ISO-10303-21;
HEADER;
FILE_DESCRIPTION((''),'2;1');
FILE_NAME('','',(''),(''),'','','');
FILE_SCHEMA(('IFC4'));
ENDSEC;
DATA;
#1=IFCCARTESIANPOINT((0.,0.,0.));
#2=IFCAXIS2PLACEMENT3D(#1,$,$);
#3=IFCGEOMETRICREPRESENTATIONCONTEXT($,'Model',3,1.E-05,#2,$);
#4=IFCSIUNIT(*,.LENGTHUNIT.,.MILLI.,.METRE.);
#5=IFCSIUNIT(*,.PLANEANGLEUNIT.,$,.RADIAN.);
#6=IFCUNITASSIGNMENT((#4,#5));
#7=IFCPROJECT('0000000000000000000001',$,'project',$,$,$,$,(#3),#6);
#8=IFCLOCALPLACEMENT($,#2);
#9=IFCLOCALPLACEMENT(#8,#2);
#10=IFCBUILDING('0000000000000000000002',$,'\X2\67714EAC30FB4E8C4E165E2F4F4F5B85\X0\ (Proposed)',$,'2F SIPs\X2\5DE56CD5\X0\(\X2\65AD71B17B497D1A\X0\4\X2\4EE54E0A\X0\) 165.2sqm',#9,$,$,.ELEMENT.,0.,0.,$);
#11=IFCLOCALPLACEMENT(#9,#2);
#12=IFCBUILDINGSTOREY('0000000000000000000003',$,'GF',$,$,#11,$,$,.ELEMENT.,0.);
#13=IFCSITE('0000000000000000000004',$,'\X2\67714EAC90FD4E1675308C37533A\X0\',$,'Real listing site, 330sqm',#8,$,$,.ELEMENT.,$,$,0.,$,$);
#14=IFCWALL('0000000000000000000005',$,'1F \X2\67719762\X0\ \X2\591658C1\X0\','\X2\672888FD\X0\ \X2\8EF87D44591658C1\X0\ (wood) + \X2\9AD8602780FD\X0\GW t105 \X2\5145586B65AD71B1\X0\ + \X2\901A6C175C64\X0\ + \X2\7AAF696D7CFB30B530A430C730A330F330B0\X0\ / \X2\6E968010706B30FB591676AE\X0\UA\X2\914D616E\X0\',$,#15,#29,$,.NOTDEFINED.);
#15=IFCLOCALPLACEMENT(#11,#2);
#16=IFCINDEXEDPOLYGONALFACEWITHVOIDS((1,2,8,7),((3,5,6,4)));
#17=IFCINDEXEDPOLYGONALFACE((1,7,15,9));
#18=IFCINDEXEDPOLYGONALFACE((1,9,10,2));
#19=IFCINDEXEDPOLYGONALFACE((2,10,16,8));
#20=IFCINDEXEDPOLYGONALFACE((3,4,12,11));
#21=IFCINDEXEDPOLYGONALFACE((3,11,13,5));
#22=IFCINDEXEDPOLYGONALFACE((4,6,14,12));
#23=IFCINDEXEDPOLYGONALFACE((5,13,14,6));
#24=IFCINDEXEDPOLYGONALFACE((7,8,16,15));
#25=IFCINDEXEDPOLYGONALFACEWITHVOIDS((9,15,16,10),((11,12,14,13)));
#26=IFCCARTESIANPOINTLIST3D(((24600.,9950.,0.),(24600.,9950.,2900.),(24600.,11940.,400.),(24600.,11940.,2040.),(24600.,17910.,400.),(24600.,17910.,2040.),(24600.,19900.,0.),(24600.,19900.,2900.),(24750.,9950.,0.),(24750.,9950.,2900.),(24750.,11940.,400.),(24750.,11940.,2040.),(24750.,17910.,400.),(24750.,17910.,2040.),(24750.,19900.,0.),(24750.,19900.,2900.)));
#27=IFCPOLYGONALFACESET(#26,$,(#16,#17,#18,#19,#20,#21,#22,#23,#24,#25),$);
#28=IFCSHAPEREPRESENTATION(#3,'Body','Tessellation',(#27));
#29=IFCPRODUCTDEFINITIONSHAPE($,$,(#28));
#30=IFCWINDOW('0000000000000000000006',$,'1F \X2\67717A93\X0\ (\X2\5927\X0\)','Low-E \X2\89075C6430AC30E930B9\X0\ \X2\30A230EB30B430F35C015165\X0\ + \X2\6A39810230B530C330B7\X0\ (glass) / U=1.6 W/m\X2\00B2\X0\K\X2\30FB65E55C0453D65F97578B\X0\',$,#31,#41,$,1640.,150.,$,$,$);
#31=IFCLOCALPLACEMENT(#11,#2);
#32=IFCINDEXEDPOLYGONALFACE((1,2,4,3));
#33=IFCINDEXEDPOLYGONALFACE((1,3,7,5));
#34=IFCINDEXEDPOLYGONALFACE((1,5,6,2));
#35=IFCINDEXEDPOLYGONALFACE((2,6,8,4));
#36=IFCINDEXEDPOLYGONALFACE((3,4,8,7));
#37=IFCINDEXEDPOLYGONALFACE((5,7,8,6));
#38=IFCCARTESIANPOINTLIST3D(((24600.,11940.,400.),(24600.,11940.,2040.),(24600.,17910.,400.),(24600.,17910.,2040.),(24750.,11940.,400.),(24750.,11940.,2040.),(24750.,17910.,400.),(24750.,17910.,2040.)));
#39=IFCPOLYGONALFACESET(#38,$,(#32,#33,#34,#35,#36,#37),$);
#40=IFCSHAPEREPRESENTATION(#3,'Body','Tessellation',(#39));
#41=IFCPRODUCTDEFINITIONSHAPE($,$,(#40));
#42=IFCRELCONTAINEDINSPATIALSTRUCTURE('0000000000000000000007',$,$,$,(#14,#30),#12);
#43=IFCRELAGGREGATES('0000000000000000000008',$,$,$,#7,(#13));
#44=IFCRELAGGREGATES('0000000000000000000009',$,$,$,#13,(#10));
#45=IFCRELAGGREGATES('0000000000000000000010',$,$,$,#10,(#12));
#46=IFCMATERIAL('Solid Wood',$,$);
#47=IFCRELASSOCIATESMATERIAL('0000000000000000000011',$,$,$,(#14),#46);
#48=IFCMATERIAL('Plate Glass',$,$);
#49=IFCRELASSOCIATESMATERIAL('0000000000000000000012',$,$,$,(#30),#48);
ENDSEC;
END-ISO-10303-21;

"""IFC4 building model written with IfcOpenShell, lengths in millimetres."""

from ifc_helpers import new_model, si_unit, frame, frame_2d, origin, place, context, project, spatial, rectangle, extrude, material, element, fill, save


model = new_model("IFC4")

# Units and contexts
model_context = context("Model", 3, precision=1e-05, world=origin())
ifc_project = project(units=[si_unit("LENGTHUNIT", "METRE", prefix="MILLI"), si_unit("PLANEANGLEUNIT", "RADIAN")], contexts=[model_context])

# Site, building, storey
site_placement = place(None, origin())
site = spatial("IfcSite", under=ifc_project, at=site_placement, Name="東京都世田谷区", ObjectType="Real listing site, 330sqm", CompositionType="ELEMENT", RefElevation=0.0)
building_placement = place(site_placement, origin())
building = spatial("IfcBuilding", under=site, at=building_placement, Name="東京・二世帯住宅 (Proposed)", ObjectType="2F SIPs工法(断熱等級4以上) 165.2sqm", CompositionType="ELEMENT", ElevationOfRefHeight=0.0, ElevationOfTerrain=0.0)
storey_placement = place(building_placement, origin())
storey = spatial("IfcBuildingStorey", under=building, at=storey_placement, Name="GF", CompositionType="ELEMENT", Elevation=0.0)

# Shared definitions
ifc_material_1 = material(Name="Solid Wood")

# Wall, opening, window
wall_1_placement = place(storey_placement, frame((12300.0, 4975.0, 0.0)))
wall_1 = element("IfcWall", 1, at=wall_1_placement, inside=storey, material=ifc_material_1, Name="1F 東面 外壁", Description="木製 軸組外壁 (wood) + 高性能GW t105 充填断熱 + 通気層 + 窯業系サイディング / 準耐火・外皮UA配慮", PredefinedType="NOTDEFINED", context=model_context, shape_type="SweptSolid", body=[
    extrude(rectangle(XDim=150.0, YDim=9950.0, at=frame_2d((75.0, 4975.0))), frame((12300.0, 4975.0, 0.0)), (0.0, 0.0, 1.0), 2900.0),
])
opening_1_placement = place(storey_placement, frame((12300.0, 5970.0, 200.0)))
opening_1 = element("IfcOpeningElement", 2, at=opening_1_placement, cuts=wall_1, PredefinedType="NOTDEFINED", context=model_context, shape_type="SweptSolid", body=[
    extrude(rectangle(XDim=150.0, YDim=5970.0, at=frame_2d((75.0, 2985.0))), frame((12300.0, 5970.0, 200.0)), (0.0, 0.0, 1.0), 1640.0),
])
ifc_material_2 = material(Name="Plate Glass")
window_1_placement = place(storey_placement, frame((12300.0, 5970.0, 200.0)))
window_1 = element("IfcWindow", 3, at=window_1_placement, inside=storey, material=ifc_material_2, Name="1F 東窓 (大)", Description="Low-E 複層ガラス アルゴン封入 + 樹脂サッシ (glass) / U=1.6 W/m²K・日射取得型", OverallHeight=1640.0, OverallWidth=150.0, context=model_context, shape_type="SweptSolid", body=[
    extrude(rectangle(XDim=150.0, YDim=5970.0, at=frame_2d((75.0, 2985.0))), frame((12300.0, 5970.0, 200.0)), (0.0, 0.0, 1.0), 1640.0),
])
fill(opening_1, window_1)

save(model, "model.ifc")
